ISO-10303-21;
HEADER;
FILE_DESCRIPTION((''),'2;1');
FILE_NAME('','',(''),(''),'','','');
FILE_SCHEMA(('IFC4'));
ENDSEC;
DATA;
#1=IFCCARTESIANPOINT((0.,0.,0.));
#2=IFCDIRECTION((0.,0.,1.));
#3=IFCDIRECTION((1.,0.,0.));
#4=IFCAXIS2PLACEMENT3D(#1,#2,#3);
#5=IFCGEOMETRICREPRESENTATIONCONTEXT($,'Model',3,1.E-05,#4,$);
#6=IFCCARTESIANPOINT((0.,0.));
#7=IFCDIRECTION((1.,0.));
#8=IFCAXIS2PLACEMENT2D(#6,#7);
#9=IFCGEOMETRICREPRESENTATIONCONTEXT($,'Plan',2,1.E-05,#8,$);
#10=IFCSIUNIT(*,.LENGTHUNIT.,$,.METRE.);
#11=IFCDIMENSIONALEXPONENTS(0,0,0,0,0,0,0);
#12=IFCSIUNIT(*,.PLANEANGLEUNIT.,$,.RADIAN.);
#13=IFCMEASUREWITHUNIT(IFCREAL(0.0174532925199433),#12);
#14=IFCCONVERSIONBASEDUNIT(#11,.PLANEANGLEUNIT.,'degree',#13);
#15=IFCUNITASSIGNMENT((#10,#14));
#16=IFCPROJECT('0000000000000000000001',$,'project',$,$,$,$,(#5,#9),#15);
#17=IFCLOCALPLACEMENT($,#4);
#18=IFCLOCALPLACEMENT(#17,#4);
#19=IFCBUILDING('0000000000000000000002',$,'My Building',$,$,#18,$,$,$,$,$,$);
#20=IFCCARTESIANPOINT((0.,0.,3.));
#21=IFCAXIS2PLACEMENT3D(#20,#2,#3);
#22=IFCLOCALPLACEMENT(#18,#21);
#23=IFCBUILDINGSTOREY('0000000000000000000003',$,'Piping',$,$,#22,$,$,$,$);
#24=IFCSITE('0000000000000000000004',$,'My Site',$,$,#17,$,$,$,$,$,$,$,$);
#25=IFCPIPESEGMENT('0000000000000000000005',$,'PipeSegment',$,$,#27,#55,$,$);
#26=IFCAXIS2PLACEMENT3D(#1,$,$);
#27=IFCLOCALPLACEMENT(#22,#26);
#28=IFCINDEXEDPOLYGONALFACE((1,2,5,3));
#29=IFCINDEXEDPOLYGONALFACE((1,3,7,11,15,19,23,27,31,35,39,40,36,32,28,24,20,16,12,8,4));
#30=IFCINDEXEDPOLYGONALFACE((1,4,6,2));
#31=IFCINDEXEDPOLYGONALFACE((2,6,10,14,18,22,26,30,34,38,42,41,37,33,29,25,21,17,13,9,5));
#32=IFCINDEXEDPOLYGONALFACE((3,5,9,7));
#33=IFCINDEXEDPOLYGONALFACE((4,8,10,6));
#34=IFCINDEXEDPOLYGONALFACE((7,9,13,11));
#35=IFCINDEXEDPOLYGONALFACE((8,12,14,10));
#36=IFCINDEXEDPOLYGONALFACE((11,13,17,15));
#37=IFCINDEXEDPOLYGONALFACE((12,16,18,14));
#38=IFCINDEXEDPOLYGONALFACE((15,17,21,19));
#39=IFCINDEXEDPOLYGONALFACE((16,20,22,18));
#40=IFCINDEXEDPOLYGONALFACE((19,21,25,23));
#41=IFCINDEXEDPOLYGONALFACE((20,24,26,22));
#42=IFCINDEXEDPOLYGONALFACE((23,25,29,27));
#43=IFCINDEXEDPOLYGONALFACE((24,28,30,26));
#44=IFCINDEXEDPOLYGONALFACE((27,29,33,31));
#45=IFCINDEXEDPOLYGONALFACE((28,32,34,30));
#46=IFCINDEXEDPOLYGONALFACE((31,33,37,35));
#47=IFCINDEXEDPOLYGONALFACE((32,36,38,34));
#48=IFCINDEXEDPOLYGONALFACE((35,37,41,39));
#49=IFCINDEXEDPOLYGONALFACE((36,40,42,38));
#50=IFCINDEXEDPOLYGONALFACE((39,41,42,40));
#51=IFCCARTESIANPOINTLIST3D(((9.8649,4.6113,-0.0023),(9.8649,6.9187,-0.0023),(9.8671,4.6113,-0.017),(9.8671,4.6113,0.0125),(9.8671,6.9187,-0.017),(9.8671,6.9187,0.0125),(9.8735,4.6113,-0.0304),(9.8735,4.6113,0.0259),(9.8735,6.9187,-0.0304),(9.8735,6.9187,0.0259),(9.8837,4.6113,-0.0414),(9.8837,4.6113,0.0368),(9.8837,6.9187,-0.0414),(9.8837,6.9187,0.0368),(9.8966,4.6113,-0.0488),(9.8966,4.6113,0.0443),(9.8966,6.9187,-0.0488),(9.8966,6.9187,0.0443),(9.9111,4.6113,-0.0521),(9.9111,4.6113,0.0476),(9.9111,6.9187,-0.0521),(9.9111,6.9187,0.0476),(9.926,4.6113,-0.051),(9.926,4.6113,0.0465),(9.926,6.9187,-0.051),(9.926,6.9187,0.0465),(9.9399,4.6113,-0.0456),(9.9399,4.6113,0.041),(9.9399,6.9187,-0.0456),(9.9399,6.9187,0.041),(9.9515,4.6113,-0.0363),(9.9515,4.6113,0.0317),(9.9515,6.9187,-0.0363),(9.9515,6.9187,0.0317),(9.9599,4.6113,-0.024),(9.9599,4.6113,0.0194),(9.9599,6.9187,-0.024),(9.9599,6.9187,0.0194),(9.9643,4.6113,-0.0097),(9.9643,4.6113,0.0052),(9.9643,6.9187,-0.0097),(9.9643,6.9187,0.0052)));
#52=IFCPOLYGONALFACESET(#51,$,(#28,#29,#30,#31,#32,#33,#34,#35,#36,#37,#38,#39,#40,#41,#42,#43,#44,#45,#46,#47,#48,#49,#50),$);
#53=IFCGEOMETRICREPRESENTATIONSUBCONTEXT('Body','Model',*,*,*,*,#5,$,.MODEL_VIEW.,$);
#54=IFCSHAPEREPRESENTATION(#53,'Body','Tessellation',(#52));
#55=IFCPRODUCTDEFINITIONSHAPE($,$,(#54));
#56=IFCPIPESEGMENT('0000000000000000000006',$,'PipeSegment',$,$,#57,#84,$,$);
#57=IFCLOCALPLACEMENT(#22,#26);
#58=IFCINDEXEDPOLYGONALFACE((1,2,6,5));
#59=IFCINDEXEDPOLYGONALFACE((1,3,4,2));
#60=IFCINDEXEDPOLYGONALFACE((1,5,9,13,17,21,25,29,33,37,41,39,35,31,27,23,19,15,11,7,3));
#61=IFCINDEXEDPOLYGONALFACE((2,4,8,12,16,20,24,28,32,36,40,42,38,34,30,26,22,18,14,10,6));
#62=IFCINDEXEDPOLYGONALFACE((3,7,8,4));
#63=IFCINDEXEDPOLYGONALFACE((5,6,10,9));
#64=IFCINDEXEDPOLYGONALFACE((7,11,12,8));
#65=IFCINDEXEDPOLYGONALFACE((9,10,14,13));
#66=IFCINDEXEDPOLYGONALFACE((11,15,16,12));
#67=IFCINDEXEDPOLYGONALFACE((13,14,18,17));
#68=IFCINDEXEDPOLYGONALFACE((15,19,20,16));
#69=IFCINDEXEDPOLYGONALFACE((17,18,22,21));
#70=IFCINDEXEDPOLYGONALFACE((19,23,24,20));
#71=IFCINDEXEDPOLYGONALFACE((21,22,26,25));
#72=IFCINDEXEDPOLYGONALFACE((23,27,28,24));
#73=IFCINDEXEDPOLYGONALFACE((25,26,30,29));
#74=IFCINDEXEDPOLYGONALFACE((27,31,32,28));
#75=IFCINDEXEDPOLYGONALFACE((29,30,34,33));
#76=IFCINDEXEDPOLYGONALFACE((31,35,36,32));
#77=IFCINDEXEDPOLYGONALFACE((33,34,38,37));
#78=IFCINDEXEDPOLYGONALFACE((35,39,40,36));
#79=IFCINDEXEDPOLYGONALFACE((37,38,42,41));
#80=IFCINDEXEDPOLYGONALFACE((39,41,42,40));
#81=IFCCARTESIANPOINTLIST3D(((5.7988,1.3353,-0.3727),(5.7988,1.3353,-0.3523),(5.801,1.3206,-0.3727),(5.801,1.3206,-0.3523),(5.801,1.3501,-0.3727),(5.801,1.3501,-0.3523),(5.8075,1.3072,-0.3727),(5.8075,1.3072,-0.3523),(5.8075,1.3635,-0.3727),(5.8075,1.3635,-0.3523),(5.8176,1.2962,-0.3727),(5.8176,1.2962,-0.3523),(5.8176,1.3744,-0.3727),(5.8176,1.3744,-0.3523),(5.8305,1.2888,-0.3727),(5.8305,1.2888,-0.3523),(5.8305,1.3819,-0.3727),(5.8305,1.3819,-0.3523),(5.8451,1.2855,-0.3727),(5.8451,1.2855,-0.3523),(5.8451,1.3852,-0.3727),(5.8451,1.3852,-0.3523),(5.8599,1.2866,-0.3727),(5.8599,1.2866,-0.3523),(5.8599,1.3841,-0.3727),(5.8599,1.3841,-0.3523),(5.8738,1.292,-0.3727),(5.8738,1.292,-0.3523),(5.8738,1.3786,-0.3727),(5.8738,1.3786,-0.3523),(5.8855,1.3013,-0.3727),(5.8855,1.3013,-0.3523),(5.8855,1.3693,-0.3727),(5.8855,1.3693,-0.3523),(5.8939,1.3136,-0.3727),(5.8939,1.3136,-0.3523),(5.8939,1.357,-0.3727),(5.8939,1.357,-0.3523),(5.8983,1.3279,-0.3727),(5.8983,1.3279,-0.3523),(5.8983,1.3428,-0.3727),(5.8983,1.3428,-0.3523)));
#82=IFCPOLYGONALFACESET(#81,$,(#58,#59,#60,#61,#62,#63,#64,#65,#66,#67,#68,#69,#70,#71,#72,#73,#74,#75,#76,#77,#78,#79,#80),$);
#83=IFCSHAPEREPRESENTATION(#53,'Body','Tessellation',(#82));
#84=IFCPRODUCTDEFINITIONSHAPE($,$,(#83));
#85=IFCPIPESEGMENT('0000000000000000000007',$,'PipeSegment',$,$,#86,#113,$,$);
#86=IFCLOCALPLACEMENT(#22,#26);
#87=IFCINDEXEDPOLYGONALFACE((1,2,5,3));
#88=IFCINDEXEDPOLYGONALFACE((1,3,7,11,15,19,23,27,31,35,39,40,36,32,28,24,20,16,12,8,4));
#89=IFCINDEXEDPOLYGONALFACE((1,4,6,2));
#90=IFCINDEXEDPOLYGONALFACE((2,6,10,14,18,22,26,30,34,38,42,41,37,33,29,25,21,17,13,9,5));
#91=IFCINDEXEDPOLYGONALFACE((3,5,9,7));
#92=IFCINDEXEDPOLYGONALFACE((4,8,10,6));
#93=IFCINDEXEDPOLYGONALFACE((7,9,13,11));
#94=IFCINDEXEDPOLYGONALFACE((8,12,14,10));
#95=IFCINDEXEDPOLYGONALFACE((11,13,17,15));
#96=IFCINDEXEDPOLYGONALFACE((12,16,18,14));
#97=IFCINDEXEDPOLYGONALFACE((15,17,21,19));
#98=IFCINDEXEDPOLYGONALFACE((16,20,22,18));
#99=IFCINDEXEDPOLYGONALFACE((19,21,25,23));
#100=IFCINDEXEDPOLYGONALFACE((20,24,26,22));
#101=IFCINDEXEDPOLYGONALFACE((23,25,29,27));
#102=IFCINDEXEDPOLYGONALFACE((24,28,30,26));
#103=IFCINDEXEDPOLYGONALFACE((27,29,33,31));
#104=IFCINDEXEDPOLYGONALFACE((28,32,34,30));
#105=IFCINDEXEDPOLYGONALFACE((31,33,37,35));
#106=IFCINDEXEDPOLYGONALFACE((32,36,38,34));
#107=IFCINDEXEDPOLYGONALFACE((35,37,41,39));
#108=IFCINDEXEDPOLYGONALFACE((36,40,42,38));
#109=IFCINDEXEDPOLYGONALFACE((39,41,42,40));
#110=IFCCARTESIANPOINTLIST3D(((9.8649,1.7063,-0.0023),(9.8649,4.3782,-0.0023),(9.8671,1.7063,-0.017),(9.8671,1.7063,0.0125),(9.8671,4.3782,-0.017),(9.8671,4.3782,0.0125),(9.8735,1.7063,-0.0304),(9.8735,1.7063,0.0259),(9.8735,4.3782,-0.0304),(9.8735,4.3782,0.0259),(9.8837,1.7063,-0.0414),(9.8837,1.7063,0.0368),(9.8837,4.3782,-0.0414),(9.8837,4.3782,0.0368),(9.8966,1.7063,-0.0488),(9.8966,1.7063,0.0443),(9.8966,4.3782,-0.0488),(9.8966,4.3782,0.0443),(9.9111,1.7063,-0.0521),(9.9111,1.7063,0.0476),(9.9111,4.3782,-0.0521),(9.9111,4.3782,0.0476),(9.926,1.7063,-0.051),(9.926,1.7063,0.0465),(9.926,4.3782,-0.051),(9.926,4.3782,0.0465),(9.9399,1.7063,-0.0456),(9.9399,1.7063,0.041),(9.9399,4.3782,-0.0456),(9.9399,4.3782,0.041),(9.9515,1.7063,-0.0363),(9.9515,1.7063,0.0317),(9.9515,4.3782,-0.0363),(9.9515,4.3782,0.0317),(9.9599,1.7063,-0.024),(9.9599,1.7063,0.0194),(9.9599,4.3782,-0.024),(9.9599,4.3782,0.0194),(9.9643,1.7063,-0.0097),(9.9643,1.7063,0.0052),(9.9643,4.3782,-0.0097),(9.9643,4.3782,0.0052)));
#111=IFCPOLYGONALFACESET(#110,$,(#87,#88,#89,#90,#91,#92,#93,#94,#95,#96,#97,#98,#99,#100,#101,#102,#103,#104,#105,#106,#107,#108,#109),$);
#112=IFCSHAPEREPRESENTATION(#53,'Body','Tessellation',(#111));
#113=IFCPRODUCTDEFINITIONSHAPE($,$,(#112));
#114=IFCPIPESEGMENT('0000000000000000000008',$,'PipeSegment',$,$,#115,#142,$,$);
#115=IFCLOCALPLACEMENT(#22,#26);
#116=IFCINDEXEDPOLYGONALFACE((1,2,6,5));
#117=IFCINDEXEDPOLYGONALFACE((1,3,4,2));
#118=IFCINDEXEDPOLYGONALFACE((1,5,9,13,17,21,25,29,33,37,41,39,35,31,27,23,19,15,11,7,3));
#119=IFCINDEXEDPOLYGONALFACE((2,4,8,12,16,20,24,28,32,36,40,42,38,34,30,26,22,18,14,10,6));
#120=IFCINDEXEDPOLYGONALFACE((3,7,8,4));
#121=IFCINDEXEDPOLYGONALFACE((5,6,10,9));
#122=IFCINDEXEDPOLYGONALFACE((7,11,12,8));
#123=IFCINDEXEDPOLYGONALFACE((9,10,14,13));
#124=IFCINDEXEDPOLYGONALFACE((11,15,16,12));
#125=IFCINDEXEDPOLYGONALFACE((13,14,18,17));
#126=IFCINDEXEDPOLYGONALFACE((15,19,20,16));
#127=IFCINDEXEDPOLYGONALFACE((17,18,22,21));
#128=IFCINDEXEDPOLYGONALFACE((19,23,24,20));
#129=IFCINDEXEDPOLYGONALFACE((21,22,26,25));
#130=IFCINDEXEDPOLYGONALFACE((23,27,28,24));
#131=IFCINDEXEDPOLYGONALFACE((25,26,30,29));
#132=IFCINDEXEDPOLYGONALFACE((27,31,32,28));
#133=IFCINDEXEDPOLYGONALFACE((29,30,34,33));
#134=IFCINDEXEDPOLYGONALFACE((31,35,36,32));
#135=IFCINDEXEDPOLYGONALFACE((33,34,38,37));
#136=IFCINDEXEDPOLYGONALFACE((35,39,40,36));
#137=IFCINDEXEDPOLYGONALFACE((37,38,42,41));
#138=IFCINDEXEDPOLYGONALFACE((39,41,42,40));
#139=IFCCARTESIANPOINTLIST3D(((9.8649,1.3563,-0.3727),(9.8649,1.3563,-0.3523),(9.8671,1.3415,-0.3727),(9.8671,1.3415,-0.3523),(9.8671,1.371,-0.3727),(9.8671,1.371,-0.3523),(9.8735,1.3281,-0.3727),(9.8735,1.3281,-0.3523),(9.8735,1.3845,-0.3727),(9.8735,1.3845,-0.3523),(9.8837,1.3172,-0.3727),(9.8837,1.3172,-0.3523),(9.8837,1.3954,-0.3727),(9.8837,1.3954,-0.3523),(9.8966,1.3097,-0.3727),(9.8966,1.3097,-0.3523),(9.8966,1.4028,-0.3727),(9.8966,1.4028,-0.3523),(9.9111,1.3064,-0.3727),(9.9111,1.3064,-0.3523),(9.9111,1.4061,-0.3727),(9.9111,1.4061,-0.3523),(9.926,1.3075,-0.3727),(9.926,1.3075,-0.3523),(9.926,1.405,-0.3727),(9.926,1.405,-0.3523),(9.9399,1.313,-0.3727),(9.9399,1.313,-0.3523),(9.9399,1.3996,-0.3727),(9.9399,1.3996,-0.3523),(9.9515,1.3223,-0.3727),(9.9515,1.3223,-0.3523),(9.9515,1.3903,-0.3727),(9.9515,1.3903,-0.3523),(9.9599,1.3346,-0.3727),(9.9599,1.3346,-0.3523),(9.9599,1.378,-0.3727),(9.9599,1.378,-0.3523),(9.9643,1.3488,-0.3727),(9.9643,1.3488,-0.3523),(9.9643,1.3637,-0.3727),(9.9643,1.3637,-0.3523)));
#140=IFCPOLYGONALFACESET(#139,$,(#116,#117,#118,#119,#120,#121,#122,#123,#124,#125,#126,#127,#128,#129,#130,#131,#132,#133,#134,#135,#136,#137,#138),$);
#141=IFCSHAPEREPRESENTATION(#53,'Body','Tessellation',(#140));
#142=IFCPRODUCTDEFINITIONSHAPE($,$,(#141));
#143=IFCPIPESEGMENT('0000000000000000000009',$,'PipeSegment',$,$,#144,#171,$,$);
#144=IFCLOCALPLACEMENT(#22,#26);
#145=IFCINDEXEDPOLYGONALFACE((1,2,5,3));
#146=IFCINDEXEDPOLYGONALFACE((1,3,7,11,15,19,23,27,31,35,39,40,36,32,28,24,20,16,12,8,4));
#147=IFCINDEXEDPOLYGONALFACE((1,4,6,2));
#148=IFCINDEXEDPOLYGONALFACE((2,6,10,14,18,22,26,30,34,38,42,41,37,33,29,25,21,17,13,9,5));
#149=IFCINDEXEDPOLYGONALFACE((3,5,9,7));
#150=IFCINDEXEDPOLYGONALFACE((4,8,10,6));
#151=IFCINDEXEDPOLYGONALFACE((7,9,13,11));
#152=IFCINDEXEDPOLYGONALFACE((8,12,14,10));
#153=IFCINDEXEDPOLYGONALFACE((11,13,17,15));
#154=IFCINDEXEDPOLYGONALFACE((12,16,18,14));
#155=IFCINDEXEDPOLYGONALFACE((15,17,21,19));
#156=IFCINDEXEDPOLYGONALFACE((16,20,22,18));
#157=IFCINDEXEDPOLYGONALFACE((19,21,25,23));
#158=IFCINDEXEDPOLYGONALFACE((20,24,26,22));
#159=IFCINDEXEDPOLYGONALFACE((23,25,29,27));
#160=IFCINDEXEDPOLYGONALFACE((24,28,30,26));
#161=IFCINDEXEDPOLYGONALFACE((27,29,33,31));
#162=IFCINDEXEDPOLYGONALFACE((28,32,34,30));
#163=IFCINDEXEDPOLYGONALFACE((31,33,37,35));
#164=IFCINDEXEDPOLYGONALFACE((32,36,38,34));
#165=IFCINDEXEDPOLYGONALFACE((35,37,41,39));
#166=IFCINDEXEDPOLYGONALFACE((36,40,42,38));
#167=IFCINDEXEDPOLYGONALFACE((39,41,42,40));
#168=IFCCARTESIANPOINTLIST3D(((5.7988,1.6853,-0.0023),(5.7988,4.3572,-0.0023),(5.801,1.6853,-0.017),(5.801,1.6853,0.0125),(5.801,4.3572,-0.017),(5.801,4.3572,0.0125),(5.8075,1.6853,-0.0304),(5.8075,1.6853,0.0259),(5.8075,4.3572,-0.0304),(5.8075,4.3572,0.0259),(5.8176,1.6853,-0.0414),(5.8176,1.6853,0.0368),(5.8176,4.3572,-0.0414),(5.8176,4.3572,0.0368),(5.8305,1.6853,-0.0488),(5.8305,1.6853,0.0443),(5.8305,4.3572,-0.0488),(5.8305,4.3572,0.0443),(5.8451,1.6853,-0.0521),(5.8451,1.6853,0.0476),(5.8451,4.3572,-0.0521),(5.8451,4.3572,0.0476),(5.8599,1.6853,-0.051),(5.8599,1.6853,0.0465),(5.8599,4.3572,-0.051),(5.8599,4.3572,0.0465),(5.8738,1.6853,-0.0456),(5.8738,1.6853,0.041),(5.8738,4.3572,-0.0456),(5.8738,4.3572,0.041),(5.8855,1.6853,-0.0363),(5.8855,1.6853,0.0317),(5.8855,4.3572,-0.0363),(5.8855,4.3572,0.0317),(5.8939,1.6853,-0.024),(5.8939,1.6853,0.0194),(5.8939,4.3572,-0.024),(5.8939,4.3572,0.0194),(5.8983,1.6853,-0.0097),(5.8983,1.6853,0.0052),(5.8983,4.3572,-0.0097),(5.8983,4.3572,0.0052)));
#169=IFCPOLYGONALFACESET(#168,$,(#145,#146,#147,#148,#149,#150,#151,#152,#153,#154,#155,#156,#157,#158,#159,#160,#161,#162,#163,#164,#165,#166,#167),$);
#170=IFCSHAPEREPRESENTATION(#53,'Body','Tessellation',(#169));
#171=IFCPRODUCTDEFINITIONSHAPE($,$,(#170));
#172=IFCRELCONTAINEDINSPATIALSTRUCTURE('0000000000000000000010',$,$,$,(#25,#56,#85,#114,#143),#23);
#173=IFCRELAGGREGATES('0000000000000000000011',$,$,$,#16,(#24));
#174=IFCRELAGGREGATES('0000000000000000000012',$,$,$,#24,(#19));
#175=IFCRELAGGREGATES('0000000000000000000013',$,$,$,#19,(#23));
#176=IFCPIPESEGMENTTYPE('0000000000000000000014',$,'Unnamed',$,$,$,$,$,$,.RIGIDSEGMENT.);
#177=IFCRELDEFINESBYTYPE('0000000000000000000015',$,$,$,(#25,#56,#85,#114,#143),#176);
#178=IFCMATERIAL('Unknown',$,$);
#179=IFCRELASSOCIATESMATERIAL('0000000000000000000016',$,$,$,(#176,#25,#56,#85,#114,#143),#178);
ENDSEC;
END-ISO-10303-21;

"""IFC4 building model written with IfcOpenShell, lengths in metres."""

from ifc_helpers import new_model, entity, si_unit, converted_unit, frame, origin_with_axes, origin_2d_with_axis, place, context, subcontext, project, spatial, circle, extrude, material, material_profile, profile_set, profile_usage, type_object, element, save


model = new_model("IFC4")

# Units and contexts
model_context = context("Model", 3, precision=1e-05, world=origin_with_axes())
plan_context = context("Plan", 2, precision=1e-05, world=origin_2d_with_axis())
body_context = subcontext(model_context, "Body", "Model", "MODEL_VIEW")
ifc_project = project(units=[si_unit("LENGTHUNIT", "METRE"), converted_unit("PLANEANGLEUNIT", "degree", entity("IfcReal", 0.0174532925199433), si_unit("PLANEANGLEUNIT", "RADIAN"), dimensions=[0, 0, 0, 0, 0, 0, 0])], contexts=[model_context, plan_context])

# Site, building, storey
site_placement = place(None, origin_with_axes())
site = spatial("IfcSite", under=ifc_project, at=site_placement, Name="My Site")
building_placement = place(site_placement, origin_with_axes())
building = spatial("IfcBuilding", under=site, at=building_placement, Name="My Building")
storey_placement = place(building_placement, frame((0.0, 0.0, 3.0), z_axis=(0.0, 0.0, 1.0), x_axis=(1.0, 0.0, 0.0)))
storey = spatial("IfcBuildingStorey", under=building, at=storey_placement, Name="Piping")

# Pipe segments
ifc_material = material(Name="Unknown")
ifc_material_profile_1 = material_profile(ifc_material, circle(Radius=0.05))
ifc_profile_set_1 = profile_set([ifc_material_profile_1])
pipe_segment_type = type_object("IfcPipeSegmentType", Name="Unnamed", PredefinedType="RIGIDSEGMENT", material=ifc_profile_set_1)
ifc_profile_usage_1 = profile_usage(ifc_profile_set_1, cardinal=5)
pipe_segment_1_placement = place(storey_placement, frame((9.9149, 4.6113, -0.0023), z_axis=(0.0, 1.0, 0.0), x_axis=(-1.0, 0.0, 0.0)))
element("IfcPipeSegment", 1, at=pipe_segment_1_placement, inside=storey, type_object=pipe_segment_type, material=ifc_profile_usage_1, Name="PipeSegment", context=body_context, shape_type="SweptSolid", body=[
    extrude(circle(Radius=0.05), origin_with_axes(), (0.0, 0.0, 1.0), 2.3074),
])
ifc_profile_usage_2 = profile_usage(ifc_profile_set_1, cardinal=5)
pipe_segment_2_placement = place(storey_placement, frame((5.8488, 1.3353, -0.3523), z_axis=(0.0, 0.0, -1.0), x_axis=(-1.0, 0.0, 0.0)))
element("IfcPipeSegment", 2, at=pipe_segment_2_placement, inside=storey, type_object=pipe_segment_type, material=ifc_profile_usage_2, Name="PipeSegment", context=body_context, shape_type="SweptSolid", body=[
    extrude(circle(Radius=0.05), origin_with_axes(), (0.0, 0.0, 1.0), 0.0204),
])
ifc_profile_usage_3 = profile_usage(ifc_profile_set_1, cardinal=5)
pipe_segment_3_placement = place(storey_placement, frame((9.9149, 1.7063, -0.0023), z_axis=(0.0, 1.0, 0.0), x_axis=(-1.0, 0.0, 0.0)))
element("IfcPipeSegment", 3, at=pipe_segment_3_placement, inside=storey, type_object=pipe_segment_type, material=ifc_profile_usage_3, Name="PipeSegment", context=body_context, shape_type="SweptSolid", body=[
    extrude(circle(Radius=0.05), origin_with_axes(), (0.0, 0.0, 1.0), 2.6719),
])
ifc_profile_usage_4 = profile_usage(ifc_profile_set_1, cardinal=5)
pipe_segment_4_placement = place(storey_placement, frame((9.9149, 1.3563, -0.3523), z_axis=(0.0, 0.0, -1.0), x_axis=(-1.0, 0.0, 0.0)))
element("IfcPipeSegment", 4, at=pipe_segment_4_placement, inside=storey, type_object=pipe_segment_type, material=ifc_profile_usage_4, Name="PipeSegment", context=body_context, shape_type="SweptSolid", body=[
    extrude(circle(Radius=0.05), origin_with_axes(), (0.0, 0.0, 1.0), 0.0204),
])
ifc_profile_usage_5 = profile_usage(ifc_profile_set_1, cardinal=5)
pipe_segment_5_placement = place(storey_placement, frame((5.8488, 1.6853, -0.0023), z_axis=(0.0, 1.0, 0.0), x_axis=(-1.0, 0.0, 0.0)))
element("IfcPipeSegment", 5, at=pipe_segment_5_placement, inside=storey, type_object=pipe_segment_type, material=ifc_profile_usage_5, Name="PipeSegment", context=body_context, shape_type="SweptSolid", body=[
    extrude(circle(Radius=0.05), origin_with_axes(), (0.0, 0.0, 1.0), 2.6719),
])

save(model, "model.ifc")
